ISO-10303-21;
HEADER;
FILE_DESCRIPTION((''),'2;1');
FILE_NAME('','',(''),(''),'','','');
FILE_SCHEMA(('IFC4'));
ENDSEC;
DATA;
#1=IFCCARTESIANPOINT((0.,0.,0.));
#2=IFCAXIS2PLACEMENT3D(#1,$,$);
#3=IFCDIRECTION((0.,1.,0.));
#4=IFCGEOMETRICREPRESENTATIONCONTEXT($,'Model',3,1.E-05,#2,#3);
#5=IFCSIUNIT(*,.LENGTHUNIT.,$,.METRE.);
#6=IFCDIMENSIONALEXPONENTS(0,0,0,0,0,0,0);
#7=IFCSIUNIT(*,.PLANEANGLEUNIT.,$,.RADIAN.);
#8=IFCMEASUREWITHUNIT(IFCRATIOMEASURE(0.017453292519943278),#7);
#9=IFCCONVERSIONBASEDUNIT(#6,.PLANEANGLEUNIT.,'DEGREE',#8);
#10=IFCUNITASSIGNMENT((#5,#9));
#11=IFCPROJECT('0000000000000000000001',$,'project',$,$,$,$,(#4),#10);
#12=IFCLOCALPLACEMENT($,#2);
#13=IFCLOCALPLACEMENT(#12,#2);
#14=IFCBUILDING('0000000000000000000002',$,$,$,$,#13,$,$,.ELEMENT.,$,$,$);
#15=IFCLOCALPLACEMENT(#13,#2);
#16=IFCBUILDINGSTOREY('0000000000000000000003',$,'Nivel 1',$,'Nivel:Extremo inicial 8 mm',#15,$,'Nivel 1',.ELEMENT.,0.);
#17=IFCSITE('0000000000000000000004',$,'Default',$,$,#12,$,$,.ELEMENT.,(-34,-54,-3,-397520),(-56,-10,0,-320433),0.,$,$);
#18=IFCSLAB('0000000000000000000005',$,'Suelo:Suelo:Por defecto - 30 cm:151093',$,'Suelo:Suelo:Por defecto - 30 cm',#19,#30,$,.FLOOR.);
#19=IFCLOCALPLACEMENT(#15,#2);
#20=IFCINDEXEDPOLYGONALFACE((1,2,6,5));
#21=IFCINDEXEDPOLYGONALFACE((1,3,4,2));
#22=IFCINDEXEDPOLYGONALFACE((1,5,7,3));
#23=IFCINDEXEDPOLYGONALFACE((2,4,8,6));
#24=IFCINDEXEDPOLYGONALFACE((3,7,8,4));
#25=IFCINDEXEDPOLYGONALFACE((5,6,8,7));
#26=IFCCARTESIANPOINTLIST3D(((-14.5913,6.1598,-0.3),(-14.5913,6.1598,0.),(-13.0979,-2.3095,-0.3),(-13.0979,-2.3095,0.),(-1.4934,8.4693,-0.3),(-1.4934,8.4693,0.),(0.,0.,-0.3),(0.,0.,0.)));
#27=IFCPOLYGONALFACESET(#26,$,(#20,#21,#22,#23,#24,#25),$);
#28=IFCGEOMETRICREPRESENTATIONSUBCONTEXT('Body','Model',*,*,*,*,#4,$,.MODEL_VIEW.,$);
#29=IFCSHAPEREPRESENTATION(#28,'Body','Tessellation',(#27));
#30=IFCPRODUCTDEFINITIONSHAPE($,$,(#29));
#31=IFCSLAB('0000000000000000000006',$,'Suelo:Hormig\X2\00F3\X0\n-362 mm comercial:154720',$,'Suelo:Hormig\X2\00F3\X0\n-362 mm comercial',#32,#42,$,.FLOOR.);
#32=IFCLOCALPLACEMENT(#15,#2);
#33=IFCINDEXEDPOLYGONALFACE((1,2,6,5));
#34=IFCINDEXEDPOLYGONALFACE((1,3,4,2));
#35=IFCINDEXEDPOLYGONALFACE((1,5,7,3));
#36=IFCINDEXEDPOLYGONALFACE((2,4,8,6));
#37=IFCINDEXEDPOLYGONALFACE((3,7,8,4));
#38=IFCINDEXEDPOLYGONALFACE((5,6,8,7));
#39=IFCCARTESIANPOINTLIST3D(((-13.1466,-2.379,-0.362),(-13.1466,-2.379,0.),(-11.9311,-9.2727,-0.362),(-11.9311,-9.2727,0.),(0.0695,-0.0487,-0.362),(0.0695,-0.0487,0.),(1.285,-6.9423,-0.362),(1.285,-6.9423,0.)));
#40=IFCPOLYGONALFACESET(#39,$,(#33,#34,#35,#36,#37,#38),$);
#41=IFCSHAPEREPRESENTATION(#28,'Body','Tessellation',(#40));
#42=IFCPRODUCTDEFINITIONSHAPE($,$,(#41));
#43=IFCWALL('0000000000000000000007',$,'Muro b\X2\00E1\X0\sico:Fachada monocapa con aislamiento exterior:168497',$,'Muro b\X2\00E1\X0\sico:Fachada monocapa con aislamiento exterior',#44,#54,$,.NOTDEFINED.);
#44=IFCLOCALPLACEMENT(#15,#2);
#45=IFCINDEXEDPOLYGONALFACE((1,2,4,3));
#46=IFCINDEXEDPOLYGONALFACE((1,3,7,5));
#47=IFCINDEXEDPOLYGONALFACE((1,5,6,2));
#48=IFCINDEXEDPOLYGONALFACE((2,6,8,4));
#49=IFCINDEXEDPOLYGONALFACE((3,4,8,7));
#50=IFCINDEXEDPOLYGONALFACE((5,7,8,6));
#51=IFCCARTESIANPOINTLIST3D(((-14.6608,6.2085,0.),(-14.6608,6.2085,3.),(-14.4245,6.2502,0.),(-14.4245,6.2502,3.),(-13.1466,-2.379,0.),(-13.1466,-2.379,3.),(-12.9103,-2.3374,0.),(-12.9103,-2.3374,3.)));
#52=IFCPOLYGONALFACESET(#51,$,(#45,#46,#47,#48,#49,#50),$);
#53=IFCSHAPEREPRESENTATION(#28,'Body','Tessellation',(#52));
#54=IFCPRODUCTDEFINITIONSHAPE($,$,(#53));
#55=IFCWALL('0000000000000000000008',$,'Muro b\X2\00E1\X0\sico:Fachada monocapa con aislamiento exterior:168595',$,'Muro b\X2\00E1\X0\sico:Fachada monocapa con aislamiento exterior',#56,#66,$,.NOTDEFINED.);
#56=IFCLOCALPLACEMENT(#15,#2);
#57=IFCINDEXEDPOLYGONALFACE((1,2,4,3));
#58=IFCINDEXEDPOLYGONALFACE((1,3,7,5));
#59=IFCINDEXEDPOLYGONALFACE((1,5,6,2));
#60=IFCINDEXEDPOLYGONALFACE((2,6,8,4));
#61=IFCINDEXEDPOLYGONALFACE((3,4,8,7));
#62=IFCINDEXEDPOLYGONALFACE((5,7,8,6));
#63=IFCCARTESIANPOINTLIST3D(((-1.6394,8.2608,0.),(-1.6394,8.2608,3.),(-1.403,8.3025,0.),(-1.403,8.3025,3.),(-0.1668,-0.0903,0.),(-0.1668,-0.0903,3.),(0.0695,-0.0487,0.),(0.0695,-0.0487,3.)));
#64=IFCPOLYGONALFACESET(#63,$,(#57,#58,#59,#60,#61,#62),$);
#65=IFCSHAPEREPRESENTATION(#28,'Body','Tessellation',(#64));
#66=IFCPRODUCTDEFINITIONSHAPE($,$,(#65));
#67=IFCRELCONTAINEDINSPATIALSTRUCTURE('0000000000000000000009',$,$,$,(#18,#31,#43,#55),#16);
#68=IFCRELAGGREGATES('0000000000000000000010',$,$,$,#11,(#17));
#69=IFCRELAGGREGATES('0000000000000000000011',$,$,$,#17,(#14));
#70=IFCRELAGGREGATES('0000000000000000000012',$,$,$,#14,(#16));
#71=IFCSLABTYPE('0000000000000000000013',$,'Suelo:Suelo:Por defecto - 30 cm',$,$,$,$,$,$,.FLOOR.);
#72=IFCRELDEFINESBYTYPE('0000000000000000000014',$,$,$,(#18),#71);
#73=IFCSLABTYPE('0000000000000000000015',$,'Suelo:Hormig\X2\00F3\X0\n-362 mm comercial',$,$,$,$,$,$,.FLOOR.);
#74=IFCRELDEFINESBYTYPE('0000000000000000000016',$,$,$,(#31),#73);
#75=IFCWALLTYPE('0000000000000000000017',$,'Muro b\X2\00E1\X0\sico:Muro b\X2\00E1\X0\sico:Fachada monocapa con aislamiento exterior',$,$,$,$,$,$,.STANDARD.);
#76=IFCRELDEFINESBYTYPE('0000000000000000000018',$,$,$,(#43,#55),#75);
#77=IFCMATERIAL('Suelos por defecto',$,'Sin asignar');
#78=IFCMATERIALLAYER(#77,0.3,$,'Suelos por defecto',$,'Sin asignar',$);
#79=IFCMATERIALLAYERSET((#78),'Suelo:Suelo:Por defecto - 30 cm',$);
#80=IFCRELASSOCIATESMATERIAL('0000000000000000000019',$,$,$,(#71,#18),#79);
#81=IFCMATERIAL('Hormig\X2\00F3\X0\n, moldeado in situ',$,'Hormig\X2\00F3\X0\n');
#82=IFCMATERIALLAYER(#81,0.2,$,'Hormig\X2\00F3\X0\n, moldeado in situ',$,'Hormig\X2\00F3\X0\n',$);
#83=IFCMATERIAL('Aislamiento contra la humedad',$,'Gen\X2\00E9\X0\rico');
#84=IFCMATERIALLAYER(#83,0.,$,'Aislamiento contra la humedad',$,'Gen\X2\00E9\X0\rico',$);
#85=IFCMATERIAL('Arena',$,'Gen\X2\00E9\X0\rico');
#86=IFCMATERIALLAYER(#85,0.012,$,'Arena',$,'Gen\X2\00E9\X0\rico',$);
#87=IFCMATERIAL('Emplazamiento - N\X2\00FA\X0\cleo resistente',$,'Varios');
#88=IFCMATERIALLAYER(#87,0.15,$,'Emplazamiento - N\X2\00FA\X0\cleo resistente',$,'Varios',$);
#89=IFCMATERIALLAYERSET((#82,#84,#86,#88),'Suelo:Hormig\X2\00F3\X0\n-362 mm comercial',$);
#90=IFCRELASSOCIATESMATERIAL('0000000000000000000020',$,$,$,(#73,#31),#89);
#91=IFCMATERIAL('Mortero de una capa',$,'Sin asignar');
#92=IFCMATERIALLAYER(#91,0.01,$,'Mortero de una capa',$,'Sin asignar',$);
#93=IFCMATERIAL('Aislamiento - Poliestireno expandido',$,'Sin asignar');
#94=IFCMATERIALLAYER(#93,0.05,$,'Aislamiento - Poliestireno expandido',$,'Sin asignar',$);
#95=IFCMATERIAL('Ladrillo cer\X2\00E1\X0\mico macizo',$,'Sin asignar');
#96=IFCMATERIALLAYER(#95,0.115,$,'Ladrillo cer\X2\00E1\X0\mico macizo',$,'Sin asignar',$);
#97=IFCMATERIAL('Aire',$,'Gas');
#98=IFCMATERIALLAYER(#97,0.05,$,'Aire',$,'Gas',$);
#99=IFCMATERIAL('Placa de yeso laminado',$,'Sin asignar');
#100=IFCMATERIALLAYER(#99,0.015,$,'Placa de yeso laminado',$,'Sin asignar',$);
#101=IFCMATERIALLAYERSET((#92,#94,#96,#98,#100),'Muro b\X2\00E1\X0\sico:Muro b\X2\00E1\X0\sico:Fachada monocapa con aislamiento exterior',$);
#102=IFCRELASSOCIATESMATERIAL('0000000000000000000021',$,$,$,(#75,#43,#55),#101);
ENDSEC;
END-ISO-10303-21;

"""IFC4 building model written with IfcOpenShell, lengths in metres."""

from ifc_helpers import new_model, entity, si_unit, converted_unit, direction, frame, frame_2d, origin, origin_2d_with_axis, place, context, subcontext, project, spatial, rectangle, extrude, material, layer, layer_set, layer_usage, type_object, element, save


model = new_model("IFC4")

# Units and contexts
model_context = context("Model", 3, precision=1e-05, world=origin(), true_north=direction((0.0, 1.0, 0.0)))
body_context = subcontext(model_context, "Body", "Model", "MODEL_VIEW")
ifc_project = project(units=[si_unit("LENGTHUNIT", "METRE"), converted_unit("PLANEANGLEUNIT", "DEGREE", entity("IfcRatioMeasure", 0.017453292519943278), si_unit("PLANEANGLEUNIT", "RADIAN"), dimensions=[0, 0, 0, 0, 0, 0, 0])], contexts=[model_context])

# Site, building, storey
site_placement = place(None, origin())
site = spatial("IfcSite", under=ifc_project, at=site_placement, Name="Default", CompositionType="ELEMENT", RefLatitude=(-34, -54, -3, -397520), RefLongitude=(-56, -10, 0, -320433), RefElevation=0.0)
building_placement = place(site_placement, origin())
building = spatial("IfcBuilding", under=site, at=building_placement, CompositionType="ELEMENT")
storey_placement = place(building_placement, origin())
storey = spatial("IfcBuildingStorey", under=building, at=storey_placement, Name="Nivel 1", ObjectType="Nivel:Extremo inicial 8 mm", LongName="Nivel 1", CompositionType="ELEMENT", Elevation=0.0)

# Slabs
ifc_material_1 = material(Name="Suelos por defecto", Category="Sin asignar")
ifc_layer_1 = layer(ifc_material_1, 0.3, Name="Suelos por defecto", Category="Sin asignar")
ifc_layer_set_1 = layer_set([ifc_layer_1], Name="Suelo:Suelo:Por defecto - 30 cm")
ifc_layer_usage_1 = layer_usage(ifc_layer_set_1, "AXIS3", "POSITIVE", 0.0)
slab_type_1 = type_object("IfcSlabType", Name="Suelo:Suelo:Por defecto - 30 cm", PredefinedType="FLOOR", material=ifc_layer_set_1)
slab_1_placement = place(storey_placement, origin())
element("IfcSlab", 1, at=slab_1_placement, inside=storey, type_object=slab_type_1, material=ifc_layer_usage_1, Name="Suelo:Suelo:Por defecto - 30 cm:151093", ObjectType="Suelo:Suelo:Por defecto - 30 cm", PredefinedType="FLOOR", context=body_context, shape_type="SweptSolid", body=[
    extrude(rectangle(XDim=13.3, YDim=8.6, at=origin_2d_with_axis()), frame((-7.2957, 3.0799, 0.0), z_axis=(0.0, 0.0, -1.0), x_axis=(0.984808, 0.173648, 0.0)), (0.0, 0.0, 1.0), 0.3),
])
ifc_material_2 = material(Name="Hormigón, moldeado in situ", Category="Hormigón")
ifc_layer_2 = layer(ifc_material_2, 0.2, Name="Hormigón, moldeado in situ", Category="Hormigón")
ifc_material_3 = material(Name="Aislamiento contra la humedad", Category="Genérico")
ifc_layer_3 = layer(ifc_material_3, 0.0, Name="Aislamiento contra la humedad", Category="Genérico")
ifc_material_4 = material(Name="Arena", Category="Genérico")
ifc_layer_4 = layer(ifc_material_4, 0.012, Name="Arena", Category="Genérico")
ifc_material_5 = material(Name="Emplazamiento - Núcleo resistente", Category="Varios")
ifc_layer_5 = layer(ifc_material_5, 0.15, Name="Emplazamiento - Núcleo resistente", Category="Varios")
ifc_layer_set_2 = layer_set([ifc_layer_2, ifc_layer_3, ifc_layer_4, ifc_layer_5], Name="Suelo:Hormigón-362 mm comercial")
ifc_layer_usage_2 = layer_usage(ifc_layer_set_2, "AXIS3", "POSITIVE", 0.0)
slab_type_2 = type_object("IfcSlabType", Name="Suelo:Hormigón-362 mm comercial", PredefinedType="FLOOR", material=ifc_layer_set_2)
slab_2_placement = place(storey_placement, origin())
element("IfcSlab", 2, at=slab_2_placement, inside=storey, type_object=slab_type_2, material=ifc_layer_usage_2, Name="Suelo:Hormigón-362 mm comercial:154720", ObjectType="Suelo:Hormigón-362 mm comercial", PredefinedType="FLOOR", context=body_context, shape_type="SweptSolid", body=[
    extrude(rectangle(XDim=7.0, YDim=13.42, at=frame_2d((0.0, 0.0), x_axis=(1.0, 0.0))), frame((-5.9308, -4.6607, 0.0), z_axis=(0.0, 0.0, -1.0), x_axis=(0.173648, -0.984808, 0.0)), (0.0, 0.0, 1.0), 0.362),
])

# Wall
ifc_material_6 = material(Name="Mortero de una capa", Category="Sin asignar")
ifc_layer_6 = layer(ifc_material_6, 0.01, Name="Mortero de una capa", Category="Sin asignar")
ifc_material_7 = material(Name="Aislamiento - Poliestireno expandido", Category="Sin asignar")
ifc_layer_7 = layer(ifc_material_7, 0.05, Name="Aislamiento - Poliestireno expandido", Category="Sin asignar")
ifc_material_8 = material(Name="Ladrillo cerámico macizo", Category="Sin asignar")
ifc_layer_8 = layer(ifc_material_8, 0.115, Name="Ladrillo cerámico macizo", Category="Sin asignar")
ifc_material_9 = material(Name="Aire", Category="Gas")
ifc_layer_9 = layer(ifc_material_9, 0.05, Name="Aire", Category="Gas")
ifc_material_10 = material(Name="Placa de yeso laminado", Category="Sin asignar")
ifc_layer_10 = layer(ifc_material_10, 0.015, Name="Placa de yeso laminado", Category="Sin asignar")
ifc_layer_set_3 = layer_set([ifc_layer_6, ifc_layer_7, ifc_layer_8, ifc_layer_9, ifc_layer_10], Name="Muro básico:Muro básico:Fachada monocapa con aislamiento exterior")
ifc_layer_usage_3 = layer_usage(ifc_layer_set_3, "AXIS2", "NEGATIVE", 0.12)
wall_type_1 = type_object("IfcWallType", Name="Muro básico:Muro básico:Fachada monocapa con aislamiento exterior", PredefinedType="STANDARD", material=ifc_layer_set_3)
wall_1_placement = place(storey_placement, frame((-13.0284, -2.3582, 0.0), z_axis=(0.0, 0.0, 1.0), x_axis=(-0.173648, 0.984808, 0.0)))
element("IfcWall", 3, at=wall_1_placement, inside=storey, type_object=wall_type_1, material=ifc_layer_usage_3, Name="Muro básico:Fachada monocapa con aislamiento exterior:168497", ObjectType="Muro básico:Fachada monocapa con aislamiento exterior", PredefinedType="NOTDEFINED", context=body_context, shape_type="SweptSolid", body=[
    extrude(rectangle(XDim=8.72, YDim=0.24, at=frame_2d((4.36, 0.0), x_axis=(-1.0, 0.0))), origin(), (0.0, 0.0, 1.0), 3.0),
])

# Wall
wall_2_placement = place(storey_placement, frame((-1.5212, 8.2817, 0.0), z_axis=(0.0, 0.0, 1.0), x_axis=(0.173648, -0.984808, 0.0)))
element("IfcWall", 4, at=wall_2_placement, inside=storey, type_object=wall_type_1, material=ifc_layer_usage_3, Name="Muro básico:Fachada monocapa con aislamiento exterior:168595", ObjectType="Muro básico:Fachada monocapa con aislamiento exterior", PredefinedType="NOTDEFINED", context=body_context, shape_type="SweptSolid", body=[
    extrude(rectangle(XDim=8.48, YDim=0.24, at=frame_2d((4.24, 0.0), x_axis=(-1.0, 0.0))), origin(), (0.0, 0.0, 1.0), 3.0),
])

save(model, "model.ifc")
